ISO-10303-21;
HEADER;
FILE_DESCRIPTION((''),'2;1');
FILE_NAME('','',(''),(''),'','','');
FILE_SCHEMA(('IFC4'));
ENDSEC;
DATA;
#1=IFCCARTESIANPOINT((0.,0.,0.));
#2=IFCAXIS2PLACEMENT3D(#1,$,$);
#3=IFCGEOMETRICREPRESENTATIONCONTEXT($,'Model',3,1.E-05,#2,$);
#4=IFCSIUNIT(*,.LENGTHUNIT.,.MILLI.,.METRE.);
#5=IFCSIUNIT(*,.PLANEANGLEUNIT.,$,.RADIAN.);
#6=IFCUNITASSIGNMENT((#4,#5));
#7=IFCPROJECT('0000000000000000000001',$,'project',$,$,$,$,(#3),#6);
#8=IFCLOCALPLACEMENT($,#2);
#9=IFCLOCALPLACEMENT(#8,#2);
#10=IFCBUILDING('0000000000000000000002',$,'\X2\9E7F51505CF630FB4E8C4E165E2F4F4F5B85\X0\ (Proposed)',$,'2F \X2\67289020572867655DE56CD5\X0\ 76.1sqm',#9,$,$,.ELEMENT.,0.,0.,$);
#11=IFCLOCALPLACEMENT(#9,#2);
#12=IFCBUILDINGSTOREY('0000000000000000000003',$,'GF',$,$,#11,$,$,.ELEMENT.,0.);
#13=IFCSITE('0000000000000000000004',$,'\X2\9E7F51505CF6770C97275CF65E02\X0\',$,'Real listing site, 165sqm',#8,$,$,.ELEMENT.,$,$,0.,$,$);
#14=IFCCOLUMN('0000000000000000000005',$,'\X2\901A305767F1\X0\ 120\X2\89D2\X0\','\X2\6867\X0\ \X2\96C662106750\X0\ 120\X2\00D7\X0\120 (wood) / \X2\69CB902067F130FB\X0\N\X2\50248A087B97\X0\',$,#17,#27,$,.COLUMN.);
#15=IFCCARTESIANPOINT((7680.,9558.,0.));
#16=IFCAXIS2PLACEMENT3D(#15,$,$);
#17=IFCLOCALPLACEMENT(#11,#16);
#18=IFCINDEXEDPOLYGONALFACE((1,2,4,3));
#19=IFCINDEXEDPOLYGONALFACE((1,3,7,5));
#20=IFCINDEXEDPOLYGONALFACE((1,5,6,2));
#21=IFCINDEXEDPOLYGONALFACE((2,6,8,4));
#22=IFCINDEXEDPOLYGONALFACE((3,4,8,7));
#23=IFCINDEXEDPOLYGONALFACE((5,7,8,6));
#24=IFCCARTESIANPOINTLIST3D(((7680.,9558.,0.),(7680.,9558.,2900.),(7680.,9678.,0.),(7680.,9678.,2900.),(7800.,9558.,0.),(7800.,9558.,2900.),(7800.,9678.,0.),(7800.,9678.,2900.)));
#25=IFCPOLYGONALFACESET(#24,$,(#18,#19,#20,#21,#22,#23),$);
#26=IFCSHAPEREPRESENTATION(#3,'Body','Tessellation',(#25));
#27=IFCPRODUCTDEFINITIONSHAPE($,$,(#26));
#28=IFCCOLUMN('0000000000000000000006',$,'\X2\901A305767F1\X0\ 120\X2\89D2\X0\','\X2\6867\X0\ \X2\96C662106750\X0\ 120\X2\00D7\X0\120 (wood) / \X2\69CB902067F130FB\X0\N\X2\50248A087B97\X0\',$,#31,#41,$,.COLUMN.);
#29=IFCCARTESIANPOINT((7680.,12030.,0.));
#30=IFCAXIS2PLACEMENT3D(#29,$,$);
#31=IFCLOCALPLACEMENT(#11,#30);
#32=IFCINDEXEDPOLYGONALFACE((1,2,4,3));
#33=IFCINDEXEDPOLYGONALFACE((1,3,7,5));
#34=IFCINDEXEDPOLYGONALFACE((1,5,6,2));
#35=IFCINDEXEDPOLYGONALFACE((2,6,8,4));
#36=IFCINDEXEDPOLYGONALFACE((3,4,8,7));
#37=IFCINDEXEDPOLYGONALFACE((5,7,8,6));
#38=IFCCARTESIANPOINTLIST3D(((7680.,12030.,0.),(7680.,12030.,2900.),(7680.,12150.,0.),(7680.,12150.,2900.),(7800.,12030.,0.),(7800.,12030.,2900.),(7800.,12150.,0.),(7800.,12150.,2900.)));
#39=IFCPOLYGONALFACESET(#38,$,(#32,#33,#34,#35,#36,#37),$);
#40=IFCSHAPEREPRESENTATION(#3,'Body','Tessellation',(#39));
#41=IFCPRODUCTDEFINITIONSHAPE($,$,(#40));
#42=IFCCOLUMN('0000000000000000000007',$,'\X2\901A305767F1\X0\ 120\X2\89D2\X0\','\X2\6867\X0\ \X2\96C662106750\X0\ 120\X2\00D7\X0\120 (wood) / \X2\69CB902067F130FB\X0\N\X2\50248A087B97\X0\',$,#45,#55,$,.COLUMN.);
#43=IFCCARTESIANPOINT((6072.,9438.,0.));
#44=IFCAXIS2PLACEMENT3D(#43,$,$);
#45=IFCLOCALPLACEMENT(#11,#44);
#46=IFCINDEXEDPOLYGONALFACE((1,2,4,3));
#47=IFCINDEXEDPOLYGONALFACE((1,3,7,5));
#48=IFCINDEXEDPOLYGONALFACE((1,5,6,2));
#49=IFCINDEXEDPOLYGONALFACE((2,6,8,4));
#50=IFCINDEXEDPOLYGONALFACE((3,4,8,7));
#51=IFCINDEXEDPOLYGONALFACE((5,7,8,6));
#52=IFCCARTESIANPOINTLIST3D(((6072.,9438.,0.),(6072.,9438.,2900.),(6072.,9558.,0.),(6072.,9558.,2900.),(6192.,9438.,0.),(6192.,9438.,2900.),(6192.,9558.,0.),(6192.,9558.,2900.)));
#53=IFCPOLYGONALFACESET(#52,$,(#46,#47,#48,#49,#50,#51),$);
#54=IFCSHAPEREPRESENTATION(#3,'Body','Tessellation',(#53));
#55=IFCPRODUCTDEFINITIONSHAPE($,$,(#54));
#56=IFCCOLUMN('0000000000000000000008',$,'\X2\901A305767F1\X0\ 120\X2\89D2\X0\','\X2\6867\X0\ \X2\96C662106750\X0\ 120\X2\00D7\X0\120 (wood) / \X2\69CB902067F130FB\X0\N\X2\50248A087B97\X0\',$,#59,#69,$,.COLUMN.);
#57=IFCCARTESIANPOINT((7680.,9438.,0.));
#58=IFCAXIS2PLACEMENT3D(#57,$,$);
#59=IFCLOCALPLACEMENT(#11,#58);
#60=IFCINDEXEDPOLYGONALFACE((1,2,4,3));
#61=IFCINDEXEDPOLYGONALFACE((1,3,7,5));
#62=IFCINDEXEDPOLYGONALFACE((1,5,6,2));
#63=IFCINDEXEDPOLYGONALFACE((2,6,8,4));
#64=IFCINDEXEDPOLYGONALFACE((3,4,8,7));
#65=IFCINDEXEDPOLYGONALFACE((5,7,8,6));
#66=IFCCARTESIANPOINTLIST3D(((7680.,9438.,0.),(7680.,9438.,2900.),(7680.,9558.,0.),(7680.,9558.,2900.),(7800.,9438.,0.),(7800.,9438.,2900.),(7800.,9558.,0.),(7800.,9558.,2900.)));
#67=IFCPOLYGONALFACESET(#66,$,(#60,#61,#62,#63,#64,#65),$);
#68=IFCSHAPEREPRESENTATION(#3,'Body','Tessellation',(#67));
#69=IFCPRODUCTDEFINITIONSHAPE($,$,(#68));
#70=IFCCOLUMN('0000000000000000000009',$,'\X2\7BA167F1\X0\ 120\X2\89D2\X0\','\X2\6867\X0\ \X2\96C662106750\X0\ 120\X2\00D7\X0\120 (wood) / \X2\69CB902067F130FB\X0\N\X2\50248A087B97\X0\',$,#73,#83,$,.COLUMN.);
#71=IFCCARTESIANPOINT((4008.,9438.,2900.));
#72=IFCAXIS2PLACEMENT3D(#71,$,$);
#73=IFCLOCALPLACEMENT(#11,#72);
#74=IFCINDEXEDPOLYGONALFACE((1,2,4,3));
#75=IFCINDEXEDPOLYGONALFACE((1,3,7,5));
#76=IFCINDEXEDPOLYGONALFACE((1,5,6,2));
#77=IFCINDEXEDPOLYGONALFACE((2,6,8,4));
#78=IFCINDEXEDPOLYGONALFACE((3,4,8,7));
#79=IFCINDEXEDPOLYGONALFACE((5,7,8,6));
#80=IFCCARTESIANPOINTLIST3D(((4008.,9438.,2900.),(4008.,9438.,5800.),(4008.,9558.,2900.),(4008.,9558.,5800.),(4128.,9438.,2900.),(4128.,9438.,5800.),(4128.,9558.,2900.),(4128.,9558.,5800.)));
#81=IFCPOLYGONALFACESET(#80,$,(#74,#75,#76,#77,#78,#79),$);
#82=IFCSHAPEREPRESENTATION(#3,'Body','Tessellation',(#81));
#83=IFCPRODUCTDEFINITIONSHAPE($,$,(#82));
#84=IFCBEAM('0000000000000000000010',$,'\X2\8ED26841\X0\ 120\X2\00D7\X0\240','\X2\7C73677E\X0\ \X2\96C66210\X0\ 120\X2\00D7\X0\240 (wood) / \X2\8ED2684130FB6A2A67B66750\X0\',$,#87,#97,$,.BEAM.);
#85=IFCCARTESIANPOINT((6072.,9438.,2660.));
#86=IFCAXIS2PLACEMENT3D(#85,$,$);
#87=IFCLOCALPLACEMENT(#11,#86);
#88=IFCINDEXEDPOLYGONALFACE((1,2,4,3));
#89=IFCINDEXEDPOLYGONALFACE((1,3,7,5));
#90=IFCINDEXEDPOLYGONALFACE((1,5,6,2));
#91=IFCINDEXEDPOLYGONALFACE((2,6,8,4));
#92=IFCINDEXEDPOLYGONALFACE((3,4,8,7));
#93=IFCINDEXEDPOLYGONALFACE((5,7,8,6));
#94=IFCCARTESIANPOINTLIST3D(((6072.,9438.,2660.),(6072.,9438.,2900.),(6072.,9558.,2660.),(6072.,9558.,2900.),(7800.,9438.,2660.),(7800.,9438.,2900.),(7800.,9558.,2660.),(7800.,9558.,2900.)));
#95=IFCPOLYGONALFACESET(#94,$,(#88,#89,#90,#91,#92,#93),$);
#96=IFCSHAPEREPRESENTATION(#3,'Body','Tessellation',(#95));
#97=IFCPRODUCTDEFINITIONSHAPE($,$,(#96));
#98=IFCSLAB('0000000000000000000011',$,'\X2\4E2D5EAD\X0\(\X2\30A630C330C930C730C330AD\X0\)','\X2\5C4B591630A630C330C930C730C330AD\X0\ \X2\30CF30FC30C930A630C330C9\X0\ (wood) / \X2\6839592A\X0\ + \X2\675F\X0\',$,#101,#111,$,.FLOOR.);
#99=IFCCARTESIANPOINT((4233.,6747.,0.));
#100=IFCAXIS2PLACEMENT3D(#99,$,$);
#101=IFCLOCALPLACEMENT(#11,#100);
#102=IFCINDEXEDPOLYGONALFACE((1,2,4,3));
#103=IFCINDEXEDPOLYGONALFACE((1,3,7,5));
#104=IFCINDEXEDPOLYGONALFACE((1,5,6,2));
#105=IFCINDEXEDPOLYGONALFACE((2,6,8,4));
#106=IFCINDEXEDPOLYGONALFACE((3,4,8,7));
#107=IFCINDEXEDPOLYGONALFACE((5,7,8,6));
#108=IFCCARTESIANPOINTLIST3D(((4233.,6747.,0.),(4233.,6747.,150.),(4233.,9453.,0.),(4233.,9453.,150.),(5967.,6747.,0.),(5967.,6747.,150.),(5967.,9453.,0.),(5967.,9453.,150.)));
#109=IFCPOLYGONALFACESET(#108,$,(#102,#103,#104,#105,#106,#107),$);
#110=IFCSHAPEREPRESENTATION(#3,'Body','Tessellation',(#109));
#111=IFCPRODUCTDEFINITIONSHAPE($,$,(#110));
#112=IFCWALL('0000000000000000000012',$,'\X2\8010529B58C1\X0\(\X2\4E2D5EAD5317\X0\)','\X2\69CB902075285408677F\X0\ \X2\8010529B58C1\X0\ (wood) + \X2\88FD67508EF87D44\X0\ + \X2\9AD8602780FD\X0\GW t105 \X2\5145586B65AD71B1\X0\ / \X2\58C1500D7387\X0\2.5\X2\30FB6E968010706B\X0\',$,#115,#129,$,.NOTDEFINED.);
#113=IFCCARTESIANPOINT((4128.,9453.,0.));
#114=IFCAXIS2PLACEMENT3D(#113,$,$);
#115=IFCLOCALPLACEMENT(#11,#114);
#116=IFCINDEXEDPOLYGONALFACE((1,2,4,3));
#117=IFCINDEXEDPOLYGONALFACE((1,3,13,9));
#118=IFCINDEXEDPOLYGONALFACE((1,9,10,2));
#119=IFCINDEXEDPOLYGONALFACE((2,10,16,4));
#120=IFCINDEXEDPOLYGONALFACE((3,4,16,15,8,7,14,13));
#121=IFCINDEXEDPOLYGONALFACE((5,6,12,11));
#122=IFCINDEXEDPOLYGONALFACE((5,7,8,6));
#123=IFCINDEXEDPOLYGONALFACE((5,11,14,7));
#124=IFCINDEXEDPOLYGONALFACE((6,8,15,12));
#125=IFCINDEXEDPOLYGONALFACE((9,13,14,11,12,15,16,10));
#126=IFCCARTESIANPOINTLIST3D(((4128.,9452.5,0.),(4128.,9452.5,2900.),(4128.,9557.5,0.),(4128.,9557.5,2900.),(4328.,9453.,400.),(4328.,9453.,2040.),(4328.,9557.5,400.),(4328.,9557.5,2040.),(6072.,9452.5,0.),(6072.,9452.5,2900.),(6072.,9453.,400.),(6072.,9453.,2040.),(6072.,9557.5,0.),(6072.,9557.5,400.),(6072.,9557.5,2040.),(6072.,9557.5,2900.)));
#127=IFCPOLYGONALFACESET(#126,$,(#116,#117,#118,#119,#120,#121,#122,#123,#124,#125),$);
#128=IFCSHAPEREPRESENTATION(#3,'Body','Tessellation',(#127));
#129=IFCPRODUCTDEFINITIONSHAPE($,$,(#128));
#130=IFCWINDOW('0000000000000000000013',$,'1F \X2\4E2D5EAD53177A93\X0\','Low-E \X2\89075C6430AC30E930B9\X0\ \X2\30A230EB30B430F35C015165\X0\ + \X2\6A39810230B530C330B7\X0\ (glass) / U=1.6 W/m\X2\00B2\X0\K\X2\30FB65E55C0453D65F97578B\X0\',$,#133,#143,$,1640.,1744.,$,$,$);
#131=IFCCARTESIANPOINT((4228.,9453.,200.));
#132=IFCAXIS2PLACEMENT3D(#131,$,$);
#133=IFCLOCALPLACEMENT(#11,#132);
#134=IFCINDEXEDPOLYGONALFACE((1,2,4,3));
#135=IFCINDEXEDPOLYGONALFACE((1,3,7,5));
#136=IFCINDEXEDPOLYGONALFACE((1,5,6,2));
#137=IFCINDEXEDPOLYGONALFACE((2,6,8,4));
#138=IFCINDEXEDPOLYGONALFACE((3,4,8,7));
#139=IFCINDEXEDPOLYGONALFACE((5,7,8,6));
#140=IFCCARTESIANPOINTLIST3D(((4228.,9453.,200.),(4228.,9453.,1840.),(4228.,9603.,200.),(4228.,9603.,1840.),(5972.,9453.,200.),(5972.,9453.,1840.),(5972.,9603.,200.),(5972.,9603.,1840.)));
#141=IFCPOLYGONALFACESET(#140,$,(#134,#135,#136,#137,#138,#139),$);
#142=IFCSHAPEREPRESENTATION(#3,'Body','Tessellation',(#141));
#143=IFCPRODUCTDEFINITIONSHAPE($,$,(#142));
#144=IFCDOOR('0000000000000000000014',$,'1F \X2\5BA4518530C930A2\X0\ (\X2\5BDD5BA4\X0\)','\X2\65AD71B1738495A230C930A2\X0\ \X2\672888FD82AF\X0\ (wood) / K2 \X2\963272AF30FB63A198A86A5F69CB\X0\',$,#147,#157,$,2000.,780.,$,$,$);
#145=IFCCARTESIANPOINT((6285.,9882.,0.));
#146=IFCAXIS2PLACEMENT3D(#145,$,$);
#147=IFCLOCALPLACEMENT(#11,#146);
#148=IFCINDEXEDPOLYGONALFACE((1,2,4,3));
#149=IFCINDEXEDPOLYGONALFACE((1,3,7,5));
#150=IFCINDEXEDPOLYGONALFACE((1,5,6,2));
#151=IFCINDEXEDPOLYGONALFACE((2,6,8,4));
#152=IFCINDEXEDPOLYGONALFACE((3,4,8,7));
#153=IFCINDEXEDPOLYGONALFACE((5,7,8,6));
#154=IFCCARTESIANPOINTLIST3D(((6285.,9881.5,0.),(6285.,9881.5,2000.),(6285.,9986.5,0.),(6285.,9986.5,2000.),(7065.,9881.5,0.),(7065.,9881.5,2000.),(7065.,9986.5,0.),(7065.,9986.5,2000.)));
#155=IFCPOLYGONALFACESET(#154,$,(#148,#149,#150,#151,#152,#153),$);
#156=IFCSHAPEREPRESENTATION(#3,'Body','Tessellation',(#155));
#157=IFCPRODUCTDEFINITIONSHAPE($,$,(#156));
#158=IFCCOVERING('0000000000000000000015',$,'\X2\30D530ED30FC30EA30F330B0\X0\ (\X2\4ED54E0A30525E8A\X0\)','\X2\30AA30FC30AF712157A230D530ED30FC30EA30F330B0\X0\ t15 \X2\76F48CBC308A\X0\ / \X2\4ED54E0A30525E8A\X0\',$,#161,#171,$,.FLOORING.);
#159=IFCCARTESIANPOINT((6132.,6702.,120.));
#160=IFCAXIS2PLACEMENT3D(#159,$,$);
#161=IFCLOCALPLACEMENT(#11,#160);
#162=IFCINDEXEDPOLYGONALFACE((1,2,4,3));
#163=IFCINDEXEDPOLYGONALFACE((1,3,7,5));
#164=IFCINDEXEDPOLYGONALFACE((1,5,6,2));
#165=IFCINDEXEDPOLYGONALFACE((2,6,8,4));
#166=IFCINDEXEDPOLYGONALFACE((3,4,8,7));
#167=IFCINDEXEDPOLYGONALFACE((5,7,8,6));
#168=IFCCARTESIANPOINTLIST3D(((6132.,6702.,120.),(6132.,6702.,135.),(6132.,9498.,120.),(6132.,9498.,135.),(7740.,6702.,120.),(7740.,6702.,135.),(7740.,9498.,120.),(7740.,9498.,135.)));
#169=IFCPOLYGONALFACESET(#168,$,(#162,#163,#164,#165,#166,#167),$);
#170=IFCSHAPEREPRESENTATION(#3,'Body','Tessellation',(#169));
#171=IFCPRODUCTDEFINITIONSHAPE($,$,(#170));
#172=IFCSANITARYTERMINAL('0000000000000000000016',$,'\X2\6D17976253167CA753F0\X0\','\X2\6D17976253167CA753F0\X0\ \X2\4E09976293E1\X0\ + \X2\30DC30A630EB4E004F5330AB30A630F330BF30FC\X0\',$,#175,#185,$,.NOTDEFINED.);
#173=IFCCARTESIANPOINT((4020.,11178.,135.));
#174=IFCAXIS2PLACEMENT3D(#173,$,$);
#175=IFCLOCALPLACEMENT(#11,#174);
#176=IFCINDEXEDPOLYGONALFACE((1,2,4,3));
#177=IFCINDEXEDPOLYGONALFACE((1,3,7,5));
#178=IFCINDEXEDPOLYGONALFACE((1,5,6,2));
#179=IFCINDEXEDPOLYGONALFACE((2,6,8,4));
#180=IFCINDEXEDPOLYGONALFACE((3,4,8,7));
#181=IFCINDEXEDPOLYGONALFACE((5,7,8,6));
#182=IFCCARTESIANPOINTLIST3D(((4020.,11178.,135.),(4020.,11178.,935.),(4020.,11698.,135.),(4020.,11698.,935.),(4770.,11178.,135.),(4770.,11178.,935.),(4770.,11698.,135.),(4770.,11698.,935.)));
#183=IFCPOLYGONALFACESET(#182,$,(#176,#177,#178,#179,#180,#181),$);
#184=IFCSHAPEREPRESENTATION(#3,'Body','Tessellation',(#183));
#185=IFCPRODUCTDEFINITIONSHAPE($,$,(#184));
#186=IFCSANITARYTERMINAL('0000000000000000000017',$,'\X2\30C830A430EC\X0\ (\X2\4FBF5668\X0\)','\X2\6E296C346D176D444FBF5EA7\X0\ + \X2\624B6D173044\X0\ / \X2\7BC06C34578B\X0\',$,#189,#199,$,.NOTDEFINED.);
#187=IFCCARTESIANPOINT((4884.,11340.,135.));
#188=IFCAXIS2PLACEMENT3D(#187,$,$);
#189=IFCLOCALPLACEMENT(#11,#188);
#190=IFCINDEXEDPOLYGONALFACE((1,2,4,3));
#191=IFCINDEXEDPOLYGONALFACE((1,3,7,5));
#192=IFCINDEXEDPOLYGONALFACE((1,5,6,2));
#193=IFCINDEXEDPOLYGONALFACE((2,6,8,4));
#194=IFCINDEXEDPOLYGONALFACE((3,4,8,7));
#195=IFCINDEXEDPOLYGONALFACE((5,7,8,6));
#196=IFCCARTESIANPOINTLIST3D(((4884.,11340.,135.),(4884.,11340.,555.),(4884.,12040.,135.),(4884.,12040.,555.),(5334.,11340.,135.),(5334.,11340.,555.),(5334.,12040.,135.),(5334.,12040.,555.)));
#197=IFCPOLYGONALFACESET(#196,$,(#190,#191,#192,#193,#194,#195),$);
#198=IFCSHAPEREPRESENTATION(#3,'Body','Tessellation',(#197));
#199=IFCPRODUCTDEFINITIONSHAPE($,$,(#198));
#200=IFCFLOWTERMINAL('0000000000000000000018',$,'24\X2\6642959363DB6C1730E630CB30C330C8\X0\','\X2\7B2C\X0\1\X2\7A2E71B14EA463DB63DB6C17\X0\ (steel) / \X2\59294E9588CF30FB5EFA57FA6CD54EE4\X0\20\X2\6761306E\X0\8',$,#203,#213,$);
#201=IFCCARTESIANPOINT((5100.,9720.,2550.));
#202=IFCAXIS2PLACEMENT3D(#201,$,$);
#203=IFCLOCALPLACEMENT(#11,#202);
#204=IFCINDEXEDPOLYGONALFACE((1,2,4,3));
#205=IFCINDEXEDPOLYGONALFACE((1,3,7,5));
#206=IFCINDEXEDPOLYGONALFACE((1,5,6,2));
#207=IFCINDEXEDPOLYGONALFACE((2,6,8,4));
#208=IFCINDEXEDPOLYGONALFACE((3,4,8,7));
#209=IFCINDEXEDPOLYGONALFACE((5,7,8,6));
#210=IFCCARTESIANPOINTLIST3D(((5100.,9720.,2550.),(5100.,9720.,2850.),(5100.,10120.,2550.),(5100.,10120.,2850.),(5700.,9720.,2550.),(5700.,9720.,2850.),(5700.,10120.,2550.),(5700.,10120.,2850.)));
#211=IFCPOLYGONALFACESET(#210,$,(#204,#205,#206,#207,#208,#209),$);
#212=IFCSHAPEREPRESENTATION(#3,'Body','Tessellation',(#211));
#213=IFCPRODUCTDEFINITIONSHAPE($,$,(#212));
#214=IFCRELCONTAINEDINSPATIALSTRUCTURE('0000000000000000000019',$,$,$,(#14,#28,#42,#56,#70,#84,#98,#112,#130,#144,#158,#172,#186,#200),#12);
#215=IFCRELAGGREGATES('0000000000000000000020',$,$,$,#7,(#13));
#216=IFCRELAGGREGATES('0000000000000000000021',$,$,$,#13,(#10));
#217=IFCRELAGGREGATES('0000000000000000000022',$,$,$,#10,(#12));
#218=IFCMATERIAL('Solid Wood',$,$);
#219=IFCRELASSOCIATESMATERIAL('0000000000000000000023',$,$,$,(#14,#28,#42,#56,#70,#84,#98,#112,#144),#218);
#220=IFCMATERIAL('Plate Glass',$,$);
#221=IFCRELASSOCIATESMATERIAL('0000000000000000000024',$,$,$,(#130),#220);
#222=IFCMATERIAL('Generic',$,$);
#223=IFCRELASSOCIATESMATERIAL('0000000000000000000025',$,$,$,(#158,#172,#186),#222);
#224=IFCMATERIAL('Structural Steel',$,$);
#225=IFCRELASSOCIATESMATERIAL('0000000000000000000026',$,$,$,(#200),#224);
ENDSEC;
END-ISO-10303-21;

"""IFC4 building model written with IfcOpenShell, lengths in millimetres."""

from ifc_helpers import new_model, si_unit, frame, frame_2d, origin, place, context, project, spatial, rectangle, extrude, material, element, fill, save


model = new_model("IFC4")

# Units and contexts
model_context = context("Model", 3, precision=1e-05, world=origin())
ifc_project = project(units=[si_unit("LENGTHUNIT", "METRE", prefix="MILLI"), si_unit("PLANEANGLEUNIT", "RADIAN")], contexts=[model_context])

# Site, building, storey
site_placement = place(None, origin())
site = spatial("IfcSite", under=ifc_project, at=site_placement, Name="鹿児島県霧島市", ObjectType="Real listing site, 165sqm", CompositionType="ELEMENT", RefElevation=0.0)
building_placement = place(site_placement, origin())
building = spatial("IfcBuilding", under=site, at=building_placement, Name="鹿児島・二世帯住宅 (Proposed)", ObjectType="2F 木造在来工法 76.1sqm", CompositionType="ELEMENT", ElevationOfRefHeight=0.0, ElevationOfTerrain=0.0)
storey_placement = place(building_placement, origin())
storey = spatial("IfcBuildingStorey", under=building, at=storey_placement, Name="GF", CompositionType="ELEMENT", Elevation=0.0)

# Columns
ifc_material_1 = material(Name="Solid Wood")
column_1_placement = place(storey_placement, frame((7680.0, 9558.0, 0.0)))
element("IfcColumn", 1, at=column_1_placement, inside=storey, material=ifc_material_1, Name="通し柱 120角", Description="桧 集成材 120×120 (wood) / 構造柱・N値計算", PredefinedType="COLUMN", context=model_context, shape_type="SweptSolid", body=[
    extrude(rectangle(XDim=120.0, YDim=120.0, at=frame_2d((60.0, 60.0))), frame((7680.0, 9558.0, 0.0)), (0.0, 0.0, 1.0), 2900.0),
])
column_2_placement = place(storey_placement, frame((7680.0, 12030.0, 0.0)))
element("IfcColumn", 2, at=column_2_placement, inside=storey, material=ifc_material_1, Name="通し柱 120角", Description="桧 集成材 120×120 (wood) / 構造柱・N値計算", PredefinedType="COLUMN", context=model_context, shape_type="SweptSolid", body=[
    extrude(rectangle(XDim=120.0, YDim=120.0, at=frame_2d((60.0, 60.0))), frame((7680.0, 12030.0, 0.0)), (0.0, 0.0, 1.0), 2900.0),
])
column_3_placement = place(storey_placement, frame((6072.0, 9438.0, 0.0)))
element("IfcColumn", 3, at=column_3_placement, inside=storey, material=ifc_material_1, Name="通し柱 120角", Description="桧 集成材 120×120 (wood) / 構造柱・N値計算", PredefinedType="COLUMN", context=model_context, shape_type="SweptSolid", body=[
    extrude(rectangle(XDim=120.0, YDim=120.0, at=frame_2d((60.0, 60.0))), frame((6072.0, 9438.0, 0.0)), (0.0, 0.0, 1.0), 2900.0),
])
column_4_placement = place(storey_placement, frame((7680.0, 9438.0, 0.0)))
element("IfcColumn", 4, at=column_4_placement, inside=storey, material=ifc_material_1, Name="通し柱 120角", Description="桧 集成材 120×120 (wood) / 構造柱・N値計算", PredefinedType="COLUMN", context=model_context, shape_type="SweptSolid", body=[
    extrude(rectangle(XDim=120.0, YDim=120.0, at=frame_2d((60.0, 60.0))), frame((7680.0, 9438.0, 0.0)), (0.0, 0.0, 1.0), 2900.0),
])
column_5_placement = place(storey_placement, frame((4008.0, 9438.0, 2900.0)))
element("IfcColumn", 5, at=column_5_placement, inside=storey, material=ifc_material_1, Name="管柱 120角", Description="桧 集成材 120×120 (wood) / 構造柱・N値計算", PredefinedType="COLUMN", context=model_context, shape_type="SweptSolid", body=[
    extrude(rectangle(XDim=120.0, YDim=120.0, at=frame_2d((60.0, 60.0))), frame((4008.0, 9438.0, 2900.0)), (0.0, 0.0, 1.0), 2900.0),
])

# Beam
beam_1_placement = place(storey_placement, frame((6072.0, 9438.0, 2660.0)))
element("IfcBeam", 6, at=beam_1_placement, inside=storey, material=ifc_material_1, Name="軒桁 120×240", Description="米松 集成 120×240 (wood) / 軒桁・横架材", PredefinedType="BEAM", context=model_context, shape_type="SweptSolid", body=[
    extrude(rectangle(XDim=1728.0, YDim=120.0, at=frame_2d((864.0, 60.0))), frame((6072.0, 9438.0, 2660.0)), (0.0, 0.0, 1.0), 240.0),
])

# Slab
slab_placement = place(storey_placement, frame((4233.0, 6747.0, 0.0)))
element("IfcSlab", 7, at=slab_placement, inside=storey, material=ifc_material_1, Name="中庭(ウッドデッキ)", Description="屋外ウッドデッキ ハードウッド (wood) / 根太 + 束", PredefinedType="FLOOR", context=model_context, shape_type="SweptSolid", body=[
    extrude(rectangle(XDim=1734.0, YDim=2706.0, at=frame_2d((867.0, 1353.0))), frame((4233.0, 6747.0, 0.0)), (0.0, 0.0, 1.0), 150.0),
])

# Wall, opening, window
wall_1_placement = place(storey_placement, frame((4128.0, 9453.0, 0.0)))
wall_1 = element("IfcWall", 8, at=wall_1_placement, inside=storey, material=ifc_material_1, Name="耐力壁(中庭北)", Description="構造用合板 耐力壁 (wood) + 製材軸組 + 高性能GW t105 充填断熱 / 壁倍率2.5・準耐火", PredefinedType="NOTDEFINED", context=model_context, shape_type="SweptSolid", body=[
    extrude(rectangle(XDim=1944.0, YDim=105.0, at=frame_2d((972.0, 52.0))), frame((4128.0, 9453.0, 0.0)), (0.0, 0.0, 1.0), 2900.0),
])
opening_placement = place(storey_placement, frame((4228.0, 9453.0, 200.0)))
opening = element("IfcOpeningElement", 9, at=opening_placement, cuts=wall_1, PredefinedType="NOTDEFINED", context=model_context, shape_type="SweptSolid", body=[
    extrude(rectangle(XDim=1744.0, YDim=150.0, at=frame_2d((872.0, 75.0))), frame((4228.0, 9453.0, 200.0)), (0.0, 0.0, 1.0), 1640.0),
])
ifc_material_2 = material(Name="Plate Glass")
window_placement = place(storey_placement, frame((4228.0, 9453.0, 200.0)))
window = element("IfcWindow", 10, at=window_placement, inside=storey, material=ifc_material_2, Name="1F 中庭北窓", Description="Low-E 複層ガラス アルゴン封入 + 樹脂サッシ (glass) / U=1.6 W/m²K・日射取得型", OverallHeight=1640.0, OverallWidth=1744.0, context=model_context, shape_type="SweptSolid", body=[
    extrude(rectangle(XDim=1744.0, YDim=150.0, at=frame_2d((872.0, 75.0))), frame((4228.0, 9453.0, 200.0)), (0.0, 0.0, 1.0), 1640.0),
])
fill(opening, window)

# Door
door_placement = place(storey_placement, frame((6285.0, 9882.0, 0.0)))
element("IfcDoor", 11, at=door_placement, inside=storey, material=ifc_material_1, Name="1F 室内ドア (寝室)", Description="断熱玄関ドア 木製芯 (wood) / K2 防犯・採風機構", OverallHeight=2000.0, OverallWidth=780.0, context=model_context, shape_type="SweptSolid", body=[
    extrude(rectangle(XDim=780.0, YDim=105.0, at=frame_2d((390.0, 52.0))), frame((6285.0, 9882.0, 0.0)), (0.0, 0.0, 1.0), 2000.0),
])

# Covering
ifc_material_3 = material(Name="Generic")
covering_placement = place(storey_placement, frame((6132.0, 6702.0, 120.0)))
element("IfcCovering", 12, at=covering_placement, inside=storey, material=ifc_material_3, Name="フローリング (仕上げ床)", Description="オーク無垢フローリング t15 直貼り / 仕上げ床", PredefinedType="FLOORING", context=model_context, shape_type="SweptSolid", body=[
    extrude(rectangle(XDim=1608.0, YDim=2796.0, at=frame_2d((804.0, 1398.0))), frame((6132.0, 6702.0, 120.0)), (0.0, 0.0, 1.0), 15.0),
])

# Sanitary terminals
sanitary_terminal_1_placement = place(storey_placement, frame((4020.0, 11178.0, 135.0)))
element("IfcSanitaryTerminal", 13, at=sanitary_terminal_1_placement, inside=storey, material=ifc_material_3, Name="洗面化粧台", Description="洗面化粧台 三面鏡 + ボウル一体カウンター", PredefinedType="NOTDEFINED", context=model_context, shape_type="SweptSolid", body=[
    extrude(rectangle(XDim=750.0, YDim=520.0, at=frame_2d((375.0, 260.0))), frame((4020.0, 11178.0, 135.0)), (0.0, 0.0, 1.0), 800.0),
])
sanitary_terminal_2_placement = place(storey_placement, frame((4884.0, 11340.0, 135.0)))
element("IfcSanitaryTerminal", 14, at=sanitary_terminal_2_placement, inside=storey, material=ifc_material_3, Name="トイレ (便器)", Description="温水洗浄便座 + 手洗い / 節水型", PredefinedType="NOTDEFINED", context=model_context, shape_type="SweptSolid", body=[
    extrude(rectangle(XDim=450.0, YDim=700.0, at=frame_2d((225.0, 350.0))), frame((4884.0, 11340.0, 135.0)), (0.0, 0.0, 1.0), 420.0),
])

# Flow terminal
ifc_material_4 = material(Name="Structural Steel")
flow_terminal_placement = place(storey_placement, frame((5100.0, 9720.0, 2550.0)))
element("IfcFlowTerminal", 15, at=flow_terminal_placement, inside=storey, material=ifc_material_4, Name="24時間換気ユニット", Description="第1種熱交換換気 (steel) / 天井裏・建基法令20条の8", context=model_context, shape_type="SweptSolid", body=[
    extrude(rectangle(XDim=600.0, YDim=400.0, at=frame_2d((300.0, 200.0))), frame((5100.0, 9720.0, 2550.0)), (0.0, 0.0, 1.0), 300.0),
])

save(model, "model.ifc")
